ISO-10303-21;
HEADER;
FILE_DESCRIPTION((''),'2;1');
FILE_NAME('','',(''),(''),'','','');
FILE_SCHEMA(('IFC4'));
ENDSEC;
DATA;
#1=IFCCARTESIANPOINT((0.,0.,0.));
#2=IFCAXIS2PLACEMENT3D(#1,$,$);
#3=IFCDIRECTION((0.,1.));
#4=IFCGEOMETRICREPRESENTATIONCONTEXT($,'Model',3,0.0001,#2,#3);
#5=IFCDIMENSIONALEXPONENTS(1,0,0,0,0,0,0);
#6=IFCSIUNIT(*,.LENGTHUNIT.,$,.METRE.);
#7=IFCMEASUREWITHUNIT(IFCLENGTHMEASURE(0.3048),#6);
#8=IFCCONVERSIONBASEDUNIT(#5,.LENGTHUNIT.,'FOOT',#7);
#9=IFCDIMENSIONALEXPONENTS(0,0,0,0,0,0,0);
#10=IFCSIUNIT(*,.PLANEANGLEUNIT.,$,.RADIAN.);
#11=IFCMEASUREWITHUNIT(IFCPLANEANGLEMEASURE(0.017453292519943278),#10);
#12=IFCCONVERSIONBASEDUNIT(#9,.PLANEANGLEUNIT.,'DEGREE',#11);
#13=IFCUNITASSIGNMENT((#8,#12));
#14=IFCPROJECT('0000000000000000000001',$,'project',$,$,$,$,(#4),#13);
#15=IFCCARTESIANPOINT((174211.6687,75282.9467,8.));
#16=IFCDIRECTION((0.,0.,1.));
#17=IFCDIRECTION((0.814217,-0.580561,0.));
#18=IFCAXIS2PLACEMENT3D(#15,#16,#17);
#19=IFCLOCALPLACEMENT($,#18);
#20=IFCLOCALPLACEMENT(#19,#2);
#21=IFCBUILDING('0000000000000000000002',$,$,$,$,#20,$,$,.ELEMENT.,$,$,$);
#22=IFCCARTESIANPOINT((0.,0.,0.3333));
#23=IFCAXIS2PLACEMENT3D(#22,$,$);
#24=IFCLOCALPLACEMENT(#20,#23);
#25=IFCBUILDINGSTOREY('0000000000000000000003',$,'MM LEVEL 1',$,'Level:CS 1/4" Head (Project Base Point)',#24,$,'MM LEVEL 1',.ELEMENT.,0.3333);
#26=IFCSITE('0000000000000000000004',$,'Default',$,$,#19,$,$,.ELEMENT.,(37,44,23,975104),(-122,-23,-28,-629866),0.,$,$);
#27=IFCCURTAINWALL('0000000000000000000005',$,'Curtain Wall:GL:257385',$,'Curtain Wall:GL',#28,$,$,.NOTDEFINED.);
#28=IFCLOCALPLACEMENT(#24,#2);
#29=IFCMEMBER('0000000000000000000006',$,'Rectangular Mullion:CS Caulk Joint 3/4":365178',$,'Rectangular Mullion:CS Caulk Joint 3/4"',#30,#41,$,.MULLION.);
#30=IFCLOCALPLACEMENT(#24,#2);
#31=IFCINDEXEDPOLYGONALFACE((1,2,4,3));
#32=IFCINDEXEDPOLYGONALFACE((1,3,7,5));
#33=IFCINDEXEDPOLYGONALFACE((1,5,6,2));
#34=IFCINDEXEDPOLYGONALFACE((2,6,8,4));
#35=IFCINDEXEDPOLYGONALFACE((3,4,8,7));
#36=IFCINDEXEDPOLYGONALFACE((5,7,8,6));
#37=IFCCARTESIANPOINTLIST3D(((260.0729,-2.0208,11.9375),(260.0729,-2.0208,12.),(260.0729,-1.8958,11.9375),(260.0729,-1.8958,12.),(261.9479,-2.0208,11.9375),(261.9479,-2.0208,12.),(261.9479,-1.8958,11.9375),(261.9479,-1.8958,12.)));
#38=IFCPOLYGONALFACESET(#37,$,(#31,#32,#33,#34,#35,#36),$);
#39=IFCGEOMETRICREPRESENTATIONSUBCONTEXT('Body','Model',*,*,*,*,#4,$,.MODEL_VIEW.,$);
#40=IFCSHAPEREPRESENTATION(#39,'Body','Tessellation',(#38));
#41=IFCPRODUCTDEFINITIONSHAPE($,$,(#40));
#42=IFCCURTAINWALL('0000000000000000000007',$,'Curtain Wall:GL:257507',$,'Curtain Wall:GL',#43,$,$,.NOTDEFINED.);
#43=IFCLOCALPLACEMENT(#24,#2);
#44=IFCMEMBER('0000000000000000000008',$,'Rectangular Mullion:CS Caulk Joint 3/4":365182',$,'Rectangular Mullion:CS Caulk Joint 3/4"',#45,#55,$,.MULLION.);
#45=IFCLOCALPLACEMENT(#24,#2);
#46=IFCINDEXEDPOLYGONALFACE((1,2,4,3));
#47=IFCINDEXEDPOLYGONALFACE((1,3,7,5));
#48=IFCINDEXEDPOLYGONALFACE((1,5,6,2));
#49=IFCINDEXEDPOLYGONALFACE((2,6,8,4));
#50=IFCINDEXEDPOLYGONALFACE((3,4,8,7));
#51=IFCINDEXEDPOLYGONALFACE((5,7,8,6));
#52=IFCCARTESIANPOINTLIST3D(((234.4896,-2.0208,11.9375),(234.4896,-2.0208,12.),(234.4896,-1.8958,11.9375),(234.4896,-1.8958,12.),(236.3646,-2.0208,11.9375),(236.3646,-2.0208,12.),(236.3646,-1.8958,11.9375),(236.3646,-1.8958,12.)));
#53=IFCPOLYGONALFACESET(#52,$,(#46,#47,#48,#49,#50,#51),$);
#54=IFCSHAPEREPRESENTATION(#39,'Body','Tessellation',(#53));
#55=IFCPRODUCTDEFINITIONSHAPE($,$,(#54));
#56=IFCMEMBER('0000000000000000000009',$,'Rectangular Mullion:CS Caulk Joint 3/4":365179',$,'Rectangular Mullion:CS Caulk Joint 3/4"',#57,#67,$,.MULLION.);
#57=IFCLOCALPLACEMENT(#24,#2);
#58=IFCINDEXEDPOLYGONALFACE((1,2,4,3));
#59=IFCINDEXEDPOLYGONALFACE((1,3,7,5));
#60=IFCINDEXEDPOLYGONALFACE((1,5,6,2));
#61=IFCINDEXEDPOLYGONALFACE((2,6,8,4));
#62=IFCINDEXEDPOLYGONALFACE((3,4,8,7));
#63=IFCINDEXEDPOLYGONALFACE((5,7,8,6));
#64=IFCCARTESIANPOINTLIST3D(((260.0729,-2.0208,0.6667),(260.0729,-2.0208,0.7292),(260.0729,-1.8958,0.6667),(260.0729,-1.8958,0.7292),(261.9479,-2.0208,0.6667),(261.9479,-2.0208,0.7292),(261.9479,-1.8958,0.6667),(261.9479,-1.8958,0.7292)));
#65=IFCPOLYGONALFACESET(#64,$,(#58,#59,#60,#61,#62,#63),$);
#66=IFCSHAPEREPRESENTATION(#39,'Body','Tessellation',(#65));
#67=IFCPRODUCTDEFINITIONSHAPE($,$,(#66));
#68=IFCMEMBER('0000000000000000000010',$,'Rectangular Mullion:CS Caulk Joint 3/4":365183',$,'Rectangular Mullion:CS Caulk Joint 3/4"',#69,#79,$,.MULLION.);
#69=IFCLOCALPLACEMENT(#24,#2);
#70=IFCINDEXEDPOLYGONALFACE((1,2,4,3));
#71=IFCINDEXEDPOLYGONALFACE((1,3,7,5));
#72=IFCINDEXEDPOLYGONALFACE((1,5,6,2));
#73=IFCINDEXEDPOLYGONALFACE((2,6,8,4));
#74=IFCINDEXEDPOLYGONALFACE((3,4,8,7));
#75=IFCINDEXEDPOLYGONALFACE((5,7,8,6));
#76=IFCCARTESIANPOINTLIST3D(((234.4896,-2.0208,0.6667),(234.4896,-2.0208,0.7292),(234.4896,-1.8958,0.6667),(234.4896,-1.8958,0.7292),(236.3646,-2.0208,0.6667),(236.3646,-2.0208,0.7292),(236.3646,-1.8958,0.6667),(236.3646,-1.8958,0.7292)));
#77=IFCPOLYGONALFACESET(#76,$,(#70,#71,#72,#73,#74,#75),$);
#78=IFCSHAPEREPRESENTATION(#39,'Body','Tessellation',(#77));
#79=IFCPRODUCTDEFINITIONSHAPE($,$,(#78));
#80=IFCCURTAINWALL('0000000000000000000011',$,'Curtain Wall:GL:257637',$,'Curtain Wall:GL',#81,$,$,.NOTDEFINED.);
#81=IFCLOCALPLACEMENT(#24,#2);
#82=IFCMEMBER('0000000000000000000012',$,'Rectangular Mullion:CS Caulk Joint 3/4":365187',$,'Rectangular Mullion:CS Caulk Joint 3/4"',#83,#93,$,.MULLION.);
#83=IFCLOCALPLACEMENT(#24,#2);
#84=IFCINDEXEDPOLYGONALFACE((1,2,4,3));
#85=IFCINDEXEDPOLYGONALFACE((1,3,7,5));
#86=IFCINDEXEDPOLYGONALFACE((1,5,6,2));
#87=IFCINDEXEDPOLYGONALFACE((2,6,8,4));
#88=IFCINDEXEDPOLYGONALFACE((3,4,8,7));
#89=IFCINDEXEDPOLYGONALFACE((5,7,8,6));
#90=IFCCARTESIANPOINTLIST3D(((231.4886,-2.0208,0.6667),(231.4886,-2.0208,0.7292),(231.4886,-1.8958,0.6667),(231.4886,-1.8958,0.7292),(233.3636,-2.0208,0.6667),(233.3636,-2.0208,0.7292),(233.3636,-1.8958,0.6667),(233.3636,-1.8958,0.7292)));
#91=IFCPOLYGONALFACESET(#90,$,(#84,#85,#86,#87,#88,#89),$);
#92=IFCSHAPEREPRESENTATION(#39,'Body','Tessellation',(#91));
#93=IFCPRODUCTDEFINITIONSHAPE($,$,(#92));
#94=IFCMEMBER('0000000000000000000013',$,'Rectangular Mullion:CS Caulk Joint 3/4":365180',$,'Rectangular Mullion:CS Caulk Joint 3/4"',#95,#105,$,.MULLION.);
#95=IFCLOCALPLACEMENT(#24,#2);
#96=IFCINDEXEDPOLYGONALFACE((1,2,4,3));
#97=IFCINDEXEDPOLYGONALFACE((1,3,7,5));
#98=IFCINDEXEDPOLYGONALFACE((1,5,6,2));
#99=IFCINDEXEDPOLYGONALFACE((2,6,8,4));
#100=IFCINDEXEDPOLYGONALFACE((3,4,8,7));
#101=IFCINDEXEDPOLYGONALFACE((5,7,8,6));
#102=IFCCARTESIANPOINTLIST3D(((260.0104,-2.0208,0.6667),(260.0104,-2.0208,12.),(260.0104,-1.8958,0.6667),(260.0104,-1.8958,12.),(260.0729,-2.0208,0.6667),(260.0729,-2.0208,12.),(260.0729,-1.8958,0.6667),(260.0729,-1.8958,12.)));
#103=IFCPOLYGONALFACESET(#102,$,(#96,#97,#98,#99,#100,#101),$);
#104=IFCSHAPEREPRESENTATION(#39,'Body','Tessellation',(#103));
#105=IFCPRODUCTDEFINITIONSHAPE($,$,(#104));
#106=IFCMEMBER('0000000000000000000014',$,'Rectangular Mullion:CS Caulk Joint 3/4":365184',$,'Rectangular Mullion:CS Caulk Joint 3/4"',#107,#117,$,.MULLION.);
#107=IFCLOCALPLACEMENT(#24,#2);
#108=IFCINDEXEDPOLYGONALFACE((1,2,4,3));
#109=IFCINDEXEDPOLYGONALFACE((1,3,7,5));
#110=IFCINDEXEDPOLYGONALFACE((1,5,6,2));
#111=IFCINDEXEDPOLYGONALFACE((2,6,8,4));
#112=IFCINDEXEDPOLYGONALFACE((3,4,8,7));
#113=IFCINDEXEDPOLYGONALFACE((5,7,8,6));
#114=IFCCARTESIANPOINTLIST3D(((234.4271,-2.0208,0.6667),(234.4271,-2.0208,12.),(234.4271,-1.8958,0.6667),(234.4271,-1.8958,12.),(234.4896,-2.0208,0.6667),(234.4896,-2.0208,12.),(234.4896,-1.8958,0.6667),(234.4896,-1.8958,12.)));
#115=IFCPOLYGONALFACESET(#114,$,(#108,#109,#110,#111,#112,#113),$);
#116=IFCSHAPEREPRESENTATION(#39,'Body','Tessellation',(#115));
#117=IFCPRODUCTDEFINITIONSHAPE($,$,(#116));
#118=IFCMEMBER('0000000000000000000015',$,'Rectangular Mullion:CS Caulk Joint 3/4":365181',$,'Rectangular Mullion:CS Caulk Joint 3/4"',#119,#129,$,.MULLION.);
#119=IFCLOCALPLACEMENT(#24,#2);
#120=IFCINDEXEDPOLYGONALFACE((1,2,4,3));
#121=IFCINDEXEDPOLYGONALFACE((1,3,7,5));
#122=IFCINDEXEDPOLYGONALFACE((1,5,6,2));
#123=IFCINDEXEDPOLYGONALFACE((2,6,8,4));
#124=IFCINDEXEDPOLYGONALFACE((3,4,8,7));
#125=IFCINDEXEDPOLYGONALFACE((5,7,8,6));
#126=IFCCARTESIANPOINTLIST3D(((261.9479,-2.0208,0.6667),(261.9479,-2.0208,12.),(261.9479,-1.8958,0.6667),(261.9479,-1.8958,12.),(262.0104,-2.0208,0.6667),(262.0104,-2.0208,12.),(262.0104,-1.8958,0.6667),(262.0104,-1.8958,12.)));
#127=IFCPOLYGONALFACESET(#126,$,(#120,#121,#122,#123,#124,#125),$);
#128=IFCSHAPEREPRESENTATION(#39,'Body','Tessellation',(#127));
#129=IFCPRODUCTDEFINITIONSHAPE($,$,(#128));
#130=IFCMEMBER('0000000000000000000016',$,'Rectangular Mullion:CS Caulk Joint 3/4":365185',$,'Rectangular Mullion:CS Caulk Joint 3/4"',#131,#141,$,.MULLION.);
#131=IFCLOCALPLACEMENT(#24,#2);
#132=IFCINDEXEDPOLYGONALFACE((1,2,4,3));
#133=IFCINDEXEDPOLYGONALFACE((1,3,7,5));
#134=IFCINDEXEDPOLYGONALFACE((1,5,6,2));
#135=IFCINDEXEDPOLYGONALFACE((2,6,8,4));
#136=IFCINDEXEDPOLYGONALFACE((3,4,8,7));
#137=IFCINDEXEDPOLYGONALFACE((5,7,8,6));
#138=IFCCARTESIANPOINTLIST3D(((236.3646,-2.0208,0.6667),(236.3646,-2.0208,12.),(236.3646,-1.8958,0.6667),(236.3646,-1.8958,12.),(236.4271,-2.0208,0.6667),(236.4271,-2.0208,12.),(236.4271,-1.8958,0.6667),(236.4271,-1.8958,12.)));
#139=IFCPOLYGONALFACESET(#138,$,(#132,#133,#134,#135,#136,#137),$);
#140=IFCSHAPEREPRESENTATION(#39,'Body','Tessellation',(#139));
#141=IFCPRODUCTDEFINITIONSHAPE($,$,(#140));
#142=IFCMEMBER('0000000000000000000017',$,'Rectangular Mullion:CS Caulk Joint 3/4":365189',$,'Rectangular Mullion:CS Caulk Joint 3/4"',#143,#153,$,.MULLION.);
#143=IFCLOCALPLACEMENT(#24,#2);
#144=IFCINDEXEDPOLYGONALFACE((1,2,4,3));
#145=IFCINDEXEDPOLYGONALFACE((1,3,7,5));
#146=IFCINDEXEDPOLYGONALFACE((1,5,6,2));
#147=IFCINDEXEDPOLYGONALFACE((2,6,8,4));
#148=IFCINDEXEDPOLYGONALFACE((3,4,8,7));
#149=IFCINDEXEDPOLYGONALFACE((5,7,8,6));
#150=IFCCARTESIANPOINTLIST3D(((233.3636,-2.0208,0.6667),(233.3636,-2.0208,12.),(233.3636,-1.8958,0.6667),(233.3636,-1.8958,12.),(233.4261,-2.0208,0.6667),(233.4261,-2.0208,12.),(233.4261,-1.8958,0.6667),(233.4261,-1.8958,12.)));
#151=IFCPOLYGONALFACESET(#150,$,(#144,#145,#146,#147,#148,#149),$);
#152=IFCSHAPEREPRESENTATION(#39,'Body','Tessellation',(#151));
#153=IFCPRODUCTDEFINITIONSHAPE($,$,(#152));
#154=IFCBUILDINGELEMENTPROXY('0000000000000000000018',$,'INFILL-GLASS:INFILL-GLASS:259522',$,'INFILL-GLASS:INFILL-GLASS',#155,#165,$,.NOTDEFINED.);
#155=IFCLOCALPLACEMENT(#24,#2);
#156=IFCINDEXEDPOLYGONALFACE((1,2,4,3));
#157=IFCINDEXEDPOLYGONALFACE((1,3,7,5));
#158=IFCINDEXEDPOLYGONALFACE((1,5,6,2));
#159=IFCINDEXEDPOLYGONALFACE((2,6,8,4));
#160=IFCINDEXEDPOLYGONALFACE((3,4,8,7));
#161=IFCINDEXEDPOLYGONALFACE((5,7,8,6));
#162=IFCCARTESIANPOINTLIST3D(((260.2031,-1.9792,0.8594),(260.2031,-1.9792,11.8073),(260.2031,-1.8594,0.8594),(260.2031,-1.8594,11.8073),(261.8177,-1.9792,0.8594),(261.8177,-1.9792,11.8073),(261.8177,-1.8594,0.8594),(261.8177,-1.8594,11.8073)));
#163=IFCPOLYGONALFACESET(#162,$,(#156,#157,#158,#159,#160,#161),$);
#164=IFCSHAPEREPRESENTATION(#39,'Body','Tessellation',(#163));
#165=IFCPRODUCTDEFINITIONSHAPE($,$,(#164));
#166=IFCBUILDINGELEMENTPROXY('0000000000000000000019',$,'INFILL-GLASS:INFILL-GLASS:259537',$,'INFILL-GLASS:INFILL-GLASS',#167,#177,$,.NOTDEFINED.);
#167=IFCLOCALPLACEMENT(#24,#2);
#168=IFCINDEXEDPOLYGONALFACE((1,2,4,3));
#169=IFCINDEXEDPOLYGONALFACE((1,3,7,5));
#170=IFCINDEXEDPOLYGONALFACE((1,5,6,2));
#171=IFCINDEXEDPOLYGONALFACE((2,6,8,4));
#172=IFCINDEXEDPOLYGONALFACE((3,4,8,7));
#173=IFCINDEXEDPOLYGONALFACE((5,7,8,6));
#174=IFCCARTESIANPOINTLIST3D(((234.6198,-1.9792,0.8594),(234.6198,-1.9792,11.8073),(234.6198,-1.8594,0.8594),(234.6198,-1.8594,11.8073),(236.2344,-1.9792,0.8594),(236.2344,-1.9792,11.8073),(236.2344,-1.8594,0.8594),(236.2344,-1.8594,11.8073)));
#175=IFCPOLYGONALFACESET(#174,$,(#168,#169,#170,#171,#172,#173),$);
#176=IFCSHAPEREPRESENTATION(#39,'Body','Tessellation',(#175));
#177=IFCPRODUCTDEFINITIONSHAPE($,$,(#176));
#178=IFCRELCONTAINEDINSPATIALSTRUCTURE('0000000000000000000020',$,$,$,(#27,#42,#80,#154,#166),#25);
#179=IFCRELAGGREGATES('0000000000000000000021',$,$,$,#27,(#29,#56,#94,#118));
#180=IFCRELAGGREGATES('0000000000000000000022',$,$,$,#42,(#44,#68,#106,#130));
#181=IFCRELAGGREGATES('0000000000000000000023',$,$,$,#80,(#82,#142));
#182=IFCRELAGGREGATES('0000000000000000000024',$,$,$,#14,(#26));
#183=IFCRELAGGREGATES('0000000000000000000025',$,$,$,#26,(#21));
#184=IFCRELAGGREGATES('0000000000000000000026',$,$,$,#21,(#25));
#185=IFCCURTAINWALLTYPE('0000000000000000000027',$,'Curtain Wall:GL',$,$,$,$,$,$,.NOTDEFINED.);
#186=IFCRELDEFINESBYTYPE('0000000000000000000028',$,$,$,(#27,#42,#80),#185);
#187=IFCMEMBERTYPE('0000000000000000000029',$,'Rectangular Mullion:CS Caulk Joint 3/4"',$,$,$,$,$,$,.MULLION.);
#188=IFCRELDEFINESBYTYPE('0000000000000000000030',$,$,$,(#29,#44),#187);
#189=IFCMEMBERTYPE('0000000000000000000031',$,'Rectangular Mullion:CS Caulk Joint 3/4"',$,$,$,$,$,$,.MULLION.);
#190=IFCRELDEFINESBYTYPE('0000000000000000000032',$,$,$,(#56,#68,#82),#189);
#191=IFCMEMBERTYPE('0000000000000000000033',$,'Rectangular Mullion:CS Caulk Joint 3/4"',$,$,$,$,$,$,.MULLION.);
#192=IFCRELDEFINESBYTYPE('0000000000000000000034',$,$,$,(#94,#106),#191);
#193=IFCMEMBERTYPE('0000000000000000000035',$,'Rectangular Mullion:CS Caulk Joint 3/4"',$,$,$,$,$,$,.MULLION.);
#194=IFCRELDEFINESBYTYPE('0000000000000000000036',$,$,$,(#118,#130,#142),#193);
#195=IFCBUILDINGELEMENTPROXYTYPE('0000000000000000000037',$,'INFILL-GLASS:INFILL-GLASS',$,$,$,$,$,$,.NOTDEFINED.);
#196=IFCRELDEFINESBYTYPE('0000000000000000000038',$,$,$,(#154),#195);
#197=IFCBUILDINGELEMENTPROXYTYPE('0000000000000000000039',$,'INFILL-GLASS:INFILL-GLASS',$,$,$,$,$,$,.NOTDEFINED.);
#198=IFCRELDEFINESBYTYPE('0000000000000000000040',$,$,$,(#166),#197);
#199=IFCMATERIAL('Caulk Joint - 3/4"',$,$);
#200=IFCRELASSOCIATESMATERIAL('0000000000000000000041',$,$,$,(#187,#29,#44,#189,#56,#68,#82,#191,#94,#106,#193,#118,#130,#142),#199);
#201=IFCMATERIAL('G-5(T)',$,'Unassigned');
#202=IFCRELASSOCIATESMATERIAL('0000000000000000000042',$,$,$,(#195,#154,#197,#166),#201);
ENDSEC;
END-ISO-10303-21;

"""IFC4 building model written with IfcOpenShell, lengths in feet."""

from ifc_helpers import new_model, entity, si_unit, converted_unit, direction, frame, origin, place, context, subcontext, project, spatial, indexed_curve, outline, extrude, source, transform, mapped, material, type_object, type_shapes, element, aggregate, save


model = new_model("IFC4")

# Units and contexts
model_context = context("Model", 3, precision=0.0001, world=origin(), true_north=direction((0.0, 1.0)))
body_context = subcontext(model_context, "Body", "Model", "MODEL_VIEW")
ifc_project = project(units=[converted_unit("LENGTHUNIT", "FOOT", entity("IfcLengthMeasure", 0.3048), si_unit("LENGTHUNIT", "METRE"), dimensions=[1, 0, 0, 0, 0, 0, 0]), converted_unit("PLANEANGLEUNIT", "DEGREE", entity("IfcPlaneAngleMeasure", 0.017453292519943278), si_unit("PLANEANGLEUNIT", "RADIAN"), dimensions=[0, 0, 0, 0, 0, 0, 0])], contexts=[model_context])

# Site, building, storey
site_placement = place(None, frame((174211.6687, 75282.9467, 8.0), z_axis=(0.0, 0.0, 1.0), x_axis=(0.814217, -0.580561, 0.0)))
site = spatial("IfcSite", under=ifc_project, at=site_placement, Name="Default", CompositionType="ELEMENT", RefLatitude=(37, 44, 23, 975104), RefLongitude=(-122, -23, -28, -629866), RefElevation=0.0)
building_placement = place(site_placement, origin())
building = spatial("IfcBuilding", under=site, at=building_placement, CompositionType="ELEMENT")
storey_placement = place(building_placement, frame((0.0, 0.0, 0.3333)))
storey = spatial("IfcBuildingStorey", under=building, at=storey_placement, Name="MM LEVEL 1", ObjectType="Level:CS 1/4\" Head (Project Base Point)", LongName="MM LEVEL 1", CompositionType="ELEMENT", Elevation=0.3333)

# Curtain walls, members
curtain_wall_type_1 = type_object("IfcCurtainWallType", Name="Curtain Wall:GL", PredefinedType="NOTDEFINED")
curtain_wall_1_placement = place(storey_placement, frame((0.0, 0.0, -0.3333)))
curtain_wall_1 = element("IfcCurtainWall", 1, at=curtain_wall_1_placement, inside=storey, type_object=curtain_wall_type_1, Name="Curtain Wall:GL:257385", ObjectType="Curtain Wall:GL", PredefinedType="NOTDEFINED")
ifc_material_1 = material(Name="Caulk Joint - 3/4\"")
member_type_1 = type_object("IfcMemberType", Name="Rectangular Mullion:CS Caulk Joint 3/4\"", PredefinedType="MULLION", material=ifc_material_1)
shared_shape_1 = source(origin(), body_context, "Body", "SweptSolid", [
    extrude(outline(indexed_curve([(-0.0625, -0.0312), (0.0625, -0.0312), (0.0625, 0.0312), (-0.0625, 0.0312), (-0.0625, -0.0312)], self_intersect=False)), frame((-0.0312, 0.0625, -1.875), z_axis=(0.0, 0.0, 1.0), x_axis=(0.0, -1.0, 0.0)), (0.0, 0.0, 1.0), 1.875),
])
type_shapes(member_type_1, [shared_shape_1])
member_1_placement = place(curtain_wall_1_placement, frame((260.0729, -2.0208, 12.3333), z_axis=(-1.0, 0.0, 0.0), x_axis=(0.0, 0.0, 1.0)))
member_1 = element("IfcMember", 2, at=member_1_placement, type_object=member_type_1, material=ifc_material_1, Name="Rectangular Mullion:CS Caulk Joint 3/4\":365178", ObjectType="Rectangular Mullion:CS Caulk Joint 3/4\"", PredefinedType="MULLION", context=body_context, shape_type="MappedRepresentation", body=[
    mapped(shared_shape_1, transform((0.0, 0.0, 0.0), scale=1.0)),
])
curtain_wall_2_placement = place(storey_placement, frame((0.0, 0.0, -0.3333)))
curtain_wall_2 = element("IfcCurtainWall", 3, at=curtain_wall_2_placement, inside=storey, type_object=curtain_wall_type_1, Name="Curtain Wall:GL:257507", ObjectType="Curtain Wall:GL", PredefinedType="NOTDEFINED")
member_2_placement = place(curtain_wall_2_placement, frame((234.4896, -2.0208, 12.3333), z_axis=(-1.0, 0.0, 0.0), x_axis=(0.0, 0.0, 1.0)))
member_2 = element("IfcMember", 4, at=member_2_placement, type_object=member_type_1, material=ifc_material_1, Name="Rectangular Mullion:CS Caulk Joint 3/4\":365182", ObjectType="Rectangular Mullion:CS Caulk Joint 3/4\"", PredefinedType="MULLION", context=body_context, shape_type="MappedRepresentation", body=[
    mapped(shared_shape_1, transform((0.0, 0.0, 0.0), scale=1.0)),
])

# Members
member_type_2 = type_object("IfcMemberType", Name="Rectangular Mullion:CS Caulk Joint 3/4\"", PredefinedType="MULLION", material=ifc_material_1)
shared_shape_2 = source(origin(), body_context, "Body", "SweptSolid", [
    extrude(outline(indexed_curve([(-0.0312, -0.0625), (0.0312, -0.0625), (0.0312, 0.0625), (-0.0312, 0.0625), (-0.0312, -0.0625)], self_intersect=False)), frame((-0.0312, 0.0625, -1.875), z_axis=(0.0, 0.0, 1.0), x_axis=(-1.0, 0.0, 0.0)), (0.0, 0.0, 1.0), 1.875),
])
type_shapes(member_type_2, [shared_shape_2])
member_3_placement = place(curtain_wall_1_placement, frame((261.9479, -2.0208, 1.0), z_axis=(1.0, 0.0, 0.0), x_axis=(0.0, 0.0, -1.0)))
member_3 = element("IfcMember", 5, at=member_3_placement, type_object=member_type_2, material=ifc_material_1, Name="Rectangular Mullion:CS Caulk Joint 3/4\":365179", ObjectType="Rectangular Mullion:CS Caulk Joint 3/4\"", PredefinedType="MULLION", context=body_context, shape_type="MappedRepresentation", body=[
    mapped(shared_shape_2, transform((0.0, 0.0, 0.0), scale=1.0)),
])
member_4_placement = place(curtain_wall_2_placement, frame((236.3646, -2.0208, 1.0), z_axis=(1.0, 0.0, 0.0), x_axis=(0.0, 0.0, -1.0)))
member_4 = element("IfcMember", 6, at=member_4_placement, type_object=member_type_2, material=ifc_material_1, Name="Rectangular Mullion:CS Caulk Joint 3/4\":365183", ObjectType="Rectangular Mullion:CS Caulk Joint 3/4\"", PredefinedType="MULLION", context=body_context, shape_type="MappedRepresentation", body=[
    mapped(shared_shape_2, transform((0.0, 0.0, 0.0), scale=1.0)),
])

# Curtain wall, member
curtain_wall_3_placement = place(storey_placement, frame((0.0, 0.0, -0.3333)))
curtain_wall_3 = element("IfcCurtainWall", 7, at=curtain_wall_3_placement, inside=storey, type_object=curtain_wall_type_1, Name="Curtain Wall:GL:257637", ObjectType="Curtain Wall:GL", PredefinedType="NOTDEFINED")
member_5_placement = place(curtain_wall_3_placement, frame((233.3636, -2.0208, 1.0), z_axis=(1.0, 0.0, 0.0), x_axis=(0.0, 0.0, -1.0)))
member_5 = element("IfcMember", 8, at=member_5_placement, type_object=member_type_2, material=ifc_material_1, Name="Rectangular Mullion:CS Caulk Joint 3/4\":365187", ObjectType="Rectangular Mullion:CS Caulk Joint 3/4\"", PredefinedType="MULLION", context=body_context, shape_type="MappedRepresentation", body=[
    mapped(shared_shape_2, transform((0.0, 0.0, 0.0), scale=1.0)),
])

# Members
member_type_3 = type_object("IfcMemberType", Name="Rectangular Mullion:CS Caulk Joint 3/4\"", PredefinedType="MULLION", material=ifc_material_1)
shared_shape_3 = source(origin(), body_context, "Body", "SweptSolid", [
    extrude(outline(indexed_curve([(-0.0625, -0.0312), (0.0625, -0.0312), (0.0625, 0.0312), (-0.0625, 0.0312), (-0.0625, -0.0312)], self_intersect=False)), frame((-0.0312, 0.0625, -11.3333), z_axis=(0.0, 0.0, 1.0), x_axis=(0.0, -1.0, 0.0)), (0.0, 0.0, 1.0), 11.3333),
])
type_shapes(member_type_3, [shared_shape_3])
member_6_placement = place(curtain_wall_1_placement, frame((260.0104, -2.0208, 1.0), z_axis=(0.0, 0.0, -1.0), x_axis=(-1.0, 0.0, 0.0)))
member_6 = element("IfcMember", 9, at=member_6_placement, type_object=member_type_3, material=ifc_material_1, Name="Rectangular Mullion:CS Caulk Joint 3/4\":365180", ObjectType="Rectangular Mullion:CS Caulk Joint 3/4\"", PredefinedType="MULLION", context=body_context, shape_type="MappedRepresentation", body=[
    mapped(shared_shape_3, transform((0.0, 0.0, 0.0), scale=1.0)),
])
member_7_placement = place(curtain_wall_2_placement, frame((234.4271, -2.0208, 1.0), z_axis=(0.0, 0.0, -1.0), x_axis=(-1.0, 0.0, 0.0)))
member_7 = element("IfcMember", 10, at=member_7_placement, type_object=member_type_3, material=ifc_material_1, Name="Rectangular Mullion:CS Caulk Joint 3/4\":365184", ObjectType="Rectangular Mullion:CS Caulk Joint 3/4\"", PredefinedType="MULLION", context=body_context, shape_type="MappedRepresentation", body=[
    mapped(shared_shape_3, transform((0.0, 0.0, 0.0), scale=1.0)),
])
member_type_4 = type_object("IfcMemberType", Name="Rectangular Mullion:CS Caulk Joint 3/4\"", PredefinedType="MULLION", material=ifc_material_1)
shared_shape_4 = source(origin(), body_context, "Body", "SweptSolid", [
    extrude(outline(indexed_curve([(-0.0312, -0.0625), (0.0312, -0.0625), (0.0312, 0.0625), (-0.0312, 0.0625), (-0.0312, -0.0625)], self_intersect=False)), frame((-0.0312, 0.0625, -11.3333), z_axis=(0.0, 0.0, 1.0), x_axis=(-1.0, 0.0, 0.0)), (0.0, 0.0, 1.0), 11.3333),
])
type_shapes(member_type_4, [shared_shape_4])
member_8_placement = place(curtain_wall_1_placement, frame((262.0104, -2.0208, 12.3333)))
member_8 = element("IfcMember", 11, at=member_8_placement, type_object=member_type_4, material=ifc_material_1, Name="Rectangular Mullion:CS Caulk Joint 3/4\":365181", ObjectType="Rectangular Mullion:CS Caulk Joint 3/4\"", PredefinedType="MULLION", context=body_context, shape_type="MappedRepresentation", body=[
    mapped(shared_shape_4, transform((0.0, 0.0, 0.0), scale=1.0)),
])
aggregate(curtain_wall_1, [member_1, member_3, member_6, member_8])
member_9_placement = place(curtain_wall_2_placement, frame((236.4271, -2.0208, 12.3333)))
member_9 = element("IfcMember", 12, at=member_9_placement, type_object=member_type_4, material=ifc_material_1, Name="Rectangular Mullion:CS Caulk Joint 3/4\":365185", ObjectType="Rectangular Mullion:CS Caulk Joint 3/4\"", PredefinedType="MULLION", context=body_context, shape_type="MappedRepresentation", body=[
    mapped(shared_shape_4, transform((0.0, 0.0, 0.0), scale=1.0)),
])
aggregate(curtain_wall_2, [member_2, member_4, member_7, member_9])
member_10_placement = place(curtain_wall_3_placement, frame((233.4261, -2.0208, 12.3333)))
member_10 = element("IfcMember", 13, at=member_10_placement, type_object=member_type_4, material=ifc_material_1, Name="Rectangular Mullion:CS Caulk Joint 3/4\":365189", ObjectType="Rectangular Mullion:CS Caulk Joint 3/4\"", PredefinedType="MULLION", context=body_context, shape_type="MappedRepresentation", body=[
    mapped(shared_shape_4, transform((0.0, 0.0, 0.0), scale=1.0)),
])
aggregate(curtain_wall_3, [member_5, member_10])

# Building element proxies
ifc_material_2 = material(Name="G-5(T)", Category="Unassigned")
building_element_proxy_type_1 = type_object("IfcBuildingElementProxyType", Name="INFILL-GLASS:INFILL-GLASS", PredefinedType="NOTDEFINED", material=ifc_material_2)
shared_shape_5 = source(origin(), body_context, "Body", "SweptSolid", [
    extrude(outline(indexed_curve([(-0.0599, -0.8073), (0.0599, -0.8073), (0.0599, 0.8073), (-0.0599, 0.8073), (-0.0599, -0.8073)], self_intersect=False)), frame((0.0, 0.1016, 0.1302), z_axis=(0.0, 0.0, 1.0), x_axis=(0.0, 1.0, 0.0)), (0.0, 0.0, 1.0), 10.9479),
])
type_shapes(building_element_proxy_type_1, [shared_shape_5])
proxy_1_placement = place(storey_placement, frame((261.0104, -2.0208, 0.7292)))
element("IfcBuildingElementProxy", 14, at=proxy_1_placement, inside=storey, type_object=building_element_proxy_type_1, material=ifc_material_2, Name="INFILL-GLASS:INFILL-GLASS:259522", ObjectType="INFILL-GLASS:INFILL-GLASS", PredefinedType="NOTDEFINED", context=body_context, shape_type="MappedRepresentation", body=[
    mapped(shared_shape_5, transform((0.0, 0.0, 0.0), scale=1.0)),
])
building_element_proxy_type_2 = type_object("IfcBuildingElementProxyType", Name="INFILL-GLASS:INFILL-GLASS", PredefinedType="NOTDEFINED", material=ifc_material_2)
shared_shape_6 = source(origin(), body_context, "Body", "SweptSolid", [
    extrude(outline(indexed_curve([(-0.0599, -0.8073), (0.0599, -0.8073), (0.0599, 0.8073), (-0.0599, 0.8073), (-0.0599, -0.8073)], self_intersect=False)), frame((0.0, 0.1016, 0.1302), z_axis=(0.0, 0.0, 1.0), x_axis=(0.0, 1.0, 0.0)), (0.0, 0.0, 1.0), 10.9479),
])
type_shapes(building_element_proxy_type_2, [shared_shape_6])
proxy_2_placement = place(storey_placement, frame((235.4271, -2.0208, 0.7292)))
element("IfcBuildingElementProxy", 15, at=proxy_2_placement, inside=storey, type_object=building_element_proxy_type_2, material=ifc_material_2, Name="INFILL-GLASS:INFILL-GLASS:259537", ObjectType="INFILL-GLASS:INFILL-GLASS", PredefinedType="NOTDEFINED", context=body_context, shape_type="MappedRepresentation", body=[
    mapped(shared_shape_6, transform((0.0, 0.0, 0.0), scale=1.0)),
])

save(model, "model.ifc")
